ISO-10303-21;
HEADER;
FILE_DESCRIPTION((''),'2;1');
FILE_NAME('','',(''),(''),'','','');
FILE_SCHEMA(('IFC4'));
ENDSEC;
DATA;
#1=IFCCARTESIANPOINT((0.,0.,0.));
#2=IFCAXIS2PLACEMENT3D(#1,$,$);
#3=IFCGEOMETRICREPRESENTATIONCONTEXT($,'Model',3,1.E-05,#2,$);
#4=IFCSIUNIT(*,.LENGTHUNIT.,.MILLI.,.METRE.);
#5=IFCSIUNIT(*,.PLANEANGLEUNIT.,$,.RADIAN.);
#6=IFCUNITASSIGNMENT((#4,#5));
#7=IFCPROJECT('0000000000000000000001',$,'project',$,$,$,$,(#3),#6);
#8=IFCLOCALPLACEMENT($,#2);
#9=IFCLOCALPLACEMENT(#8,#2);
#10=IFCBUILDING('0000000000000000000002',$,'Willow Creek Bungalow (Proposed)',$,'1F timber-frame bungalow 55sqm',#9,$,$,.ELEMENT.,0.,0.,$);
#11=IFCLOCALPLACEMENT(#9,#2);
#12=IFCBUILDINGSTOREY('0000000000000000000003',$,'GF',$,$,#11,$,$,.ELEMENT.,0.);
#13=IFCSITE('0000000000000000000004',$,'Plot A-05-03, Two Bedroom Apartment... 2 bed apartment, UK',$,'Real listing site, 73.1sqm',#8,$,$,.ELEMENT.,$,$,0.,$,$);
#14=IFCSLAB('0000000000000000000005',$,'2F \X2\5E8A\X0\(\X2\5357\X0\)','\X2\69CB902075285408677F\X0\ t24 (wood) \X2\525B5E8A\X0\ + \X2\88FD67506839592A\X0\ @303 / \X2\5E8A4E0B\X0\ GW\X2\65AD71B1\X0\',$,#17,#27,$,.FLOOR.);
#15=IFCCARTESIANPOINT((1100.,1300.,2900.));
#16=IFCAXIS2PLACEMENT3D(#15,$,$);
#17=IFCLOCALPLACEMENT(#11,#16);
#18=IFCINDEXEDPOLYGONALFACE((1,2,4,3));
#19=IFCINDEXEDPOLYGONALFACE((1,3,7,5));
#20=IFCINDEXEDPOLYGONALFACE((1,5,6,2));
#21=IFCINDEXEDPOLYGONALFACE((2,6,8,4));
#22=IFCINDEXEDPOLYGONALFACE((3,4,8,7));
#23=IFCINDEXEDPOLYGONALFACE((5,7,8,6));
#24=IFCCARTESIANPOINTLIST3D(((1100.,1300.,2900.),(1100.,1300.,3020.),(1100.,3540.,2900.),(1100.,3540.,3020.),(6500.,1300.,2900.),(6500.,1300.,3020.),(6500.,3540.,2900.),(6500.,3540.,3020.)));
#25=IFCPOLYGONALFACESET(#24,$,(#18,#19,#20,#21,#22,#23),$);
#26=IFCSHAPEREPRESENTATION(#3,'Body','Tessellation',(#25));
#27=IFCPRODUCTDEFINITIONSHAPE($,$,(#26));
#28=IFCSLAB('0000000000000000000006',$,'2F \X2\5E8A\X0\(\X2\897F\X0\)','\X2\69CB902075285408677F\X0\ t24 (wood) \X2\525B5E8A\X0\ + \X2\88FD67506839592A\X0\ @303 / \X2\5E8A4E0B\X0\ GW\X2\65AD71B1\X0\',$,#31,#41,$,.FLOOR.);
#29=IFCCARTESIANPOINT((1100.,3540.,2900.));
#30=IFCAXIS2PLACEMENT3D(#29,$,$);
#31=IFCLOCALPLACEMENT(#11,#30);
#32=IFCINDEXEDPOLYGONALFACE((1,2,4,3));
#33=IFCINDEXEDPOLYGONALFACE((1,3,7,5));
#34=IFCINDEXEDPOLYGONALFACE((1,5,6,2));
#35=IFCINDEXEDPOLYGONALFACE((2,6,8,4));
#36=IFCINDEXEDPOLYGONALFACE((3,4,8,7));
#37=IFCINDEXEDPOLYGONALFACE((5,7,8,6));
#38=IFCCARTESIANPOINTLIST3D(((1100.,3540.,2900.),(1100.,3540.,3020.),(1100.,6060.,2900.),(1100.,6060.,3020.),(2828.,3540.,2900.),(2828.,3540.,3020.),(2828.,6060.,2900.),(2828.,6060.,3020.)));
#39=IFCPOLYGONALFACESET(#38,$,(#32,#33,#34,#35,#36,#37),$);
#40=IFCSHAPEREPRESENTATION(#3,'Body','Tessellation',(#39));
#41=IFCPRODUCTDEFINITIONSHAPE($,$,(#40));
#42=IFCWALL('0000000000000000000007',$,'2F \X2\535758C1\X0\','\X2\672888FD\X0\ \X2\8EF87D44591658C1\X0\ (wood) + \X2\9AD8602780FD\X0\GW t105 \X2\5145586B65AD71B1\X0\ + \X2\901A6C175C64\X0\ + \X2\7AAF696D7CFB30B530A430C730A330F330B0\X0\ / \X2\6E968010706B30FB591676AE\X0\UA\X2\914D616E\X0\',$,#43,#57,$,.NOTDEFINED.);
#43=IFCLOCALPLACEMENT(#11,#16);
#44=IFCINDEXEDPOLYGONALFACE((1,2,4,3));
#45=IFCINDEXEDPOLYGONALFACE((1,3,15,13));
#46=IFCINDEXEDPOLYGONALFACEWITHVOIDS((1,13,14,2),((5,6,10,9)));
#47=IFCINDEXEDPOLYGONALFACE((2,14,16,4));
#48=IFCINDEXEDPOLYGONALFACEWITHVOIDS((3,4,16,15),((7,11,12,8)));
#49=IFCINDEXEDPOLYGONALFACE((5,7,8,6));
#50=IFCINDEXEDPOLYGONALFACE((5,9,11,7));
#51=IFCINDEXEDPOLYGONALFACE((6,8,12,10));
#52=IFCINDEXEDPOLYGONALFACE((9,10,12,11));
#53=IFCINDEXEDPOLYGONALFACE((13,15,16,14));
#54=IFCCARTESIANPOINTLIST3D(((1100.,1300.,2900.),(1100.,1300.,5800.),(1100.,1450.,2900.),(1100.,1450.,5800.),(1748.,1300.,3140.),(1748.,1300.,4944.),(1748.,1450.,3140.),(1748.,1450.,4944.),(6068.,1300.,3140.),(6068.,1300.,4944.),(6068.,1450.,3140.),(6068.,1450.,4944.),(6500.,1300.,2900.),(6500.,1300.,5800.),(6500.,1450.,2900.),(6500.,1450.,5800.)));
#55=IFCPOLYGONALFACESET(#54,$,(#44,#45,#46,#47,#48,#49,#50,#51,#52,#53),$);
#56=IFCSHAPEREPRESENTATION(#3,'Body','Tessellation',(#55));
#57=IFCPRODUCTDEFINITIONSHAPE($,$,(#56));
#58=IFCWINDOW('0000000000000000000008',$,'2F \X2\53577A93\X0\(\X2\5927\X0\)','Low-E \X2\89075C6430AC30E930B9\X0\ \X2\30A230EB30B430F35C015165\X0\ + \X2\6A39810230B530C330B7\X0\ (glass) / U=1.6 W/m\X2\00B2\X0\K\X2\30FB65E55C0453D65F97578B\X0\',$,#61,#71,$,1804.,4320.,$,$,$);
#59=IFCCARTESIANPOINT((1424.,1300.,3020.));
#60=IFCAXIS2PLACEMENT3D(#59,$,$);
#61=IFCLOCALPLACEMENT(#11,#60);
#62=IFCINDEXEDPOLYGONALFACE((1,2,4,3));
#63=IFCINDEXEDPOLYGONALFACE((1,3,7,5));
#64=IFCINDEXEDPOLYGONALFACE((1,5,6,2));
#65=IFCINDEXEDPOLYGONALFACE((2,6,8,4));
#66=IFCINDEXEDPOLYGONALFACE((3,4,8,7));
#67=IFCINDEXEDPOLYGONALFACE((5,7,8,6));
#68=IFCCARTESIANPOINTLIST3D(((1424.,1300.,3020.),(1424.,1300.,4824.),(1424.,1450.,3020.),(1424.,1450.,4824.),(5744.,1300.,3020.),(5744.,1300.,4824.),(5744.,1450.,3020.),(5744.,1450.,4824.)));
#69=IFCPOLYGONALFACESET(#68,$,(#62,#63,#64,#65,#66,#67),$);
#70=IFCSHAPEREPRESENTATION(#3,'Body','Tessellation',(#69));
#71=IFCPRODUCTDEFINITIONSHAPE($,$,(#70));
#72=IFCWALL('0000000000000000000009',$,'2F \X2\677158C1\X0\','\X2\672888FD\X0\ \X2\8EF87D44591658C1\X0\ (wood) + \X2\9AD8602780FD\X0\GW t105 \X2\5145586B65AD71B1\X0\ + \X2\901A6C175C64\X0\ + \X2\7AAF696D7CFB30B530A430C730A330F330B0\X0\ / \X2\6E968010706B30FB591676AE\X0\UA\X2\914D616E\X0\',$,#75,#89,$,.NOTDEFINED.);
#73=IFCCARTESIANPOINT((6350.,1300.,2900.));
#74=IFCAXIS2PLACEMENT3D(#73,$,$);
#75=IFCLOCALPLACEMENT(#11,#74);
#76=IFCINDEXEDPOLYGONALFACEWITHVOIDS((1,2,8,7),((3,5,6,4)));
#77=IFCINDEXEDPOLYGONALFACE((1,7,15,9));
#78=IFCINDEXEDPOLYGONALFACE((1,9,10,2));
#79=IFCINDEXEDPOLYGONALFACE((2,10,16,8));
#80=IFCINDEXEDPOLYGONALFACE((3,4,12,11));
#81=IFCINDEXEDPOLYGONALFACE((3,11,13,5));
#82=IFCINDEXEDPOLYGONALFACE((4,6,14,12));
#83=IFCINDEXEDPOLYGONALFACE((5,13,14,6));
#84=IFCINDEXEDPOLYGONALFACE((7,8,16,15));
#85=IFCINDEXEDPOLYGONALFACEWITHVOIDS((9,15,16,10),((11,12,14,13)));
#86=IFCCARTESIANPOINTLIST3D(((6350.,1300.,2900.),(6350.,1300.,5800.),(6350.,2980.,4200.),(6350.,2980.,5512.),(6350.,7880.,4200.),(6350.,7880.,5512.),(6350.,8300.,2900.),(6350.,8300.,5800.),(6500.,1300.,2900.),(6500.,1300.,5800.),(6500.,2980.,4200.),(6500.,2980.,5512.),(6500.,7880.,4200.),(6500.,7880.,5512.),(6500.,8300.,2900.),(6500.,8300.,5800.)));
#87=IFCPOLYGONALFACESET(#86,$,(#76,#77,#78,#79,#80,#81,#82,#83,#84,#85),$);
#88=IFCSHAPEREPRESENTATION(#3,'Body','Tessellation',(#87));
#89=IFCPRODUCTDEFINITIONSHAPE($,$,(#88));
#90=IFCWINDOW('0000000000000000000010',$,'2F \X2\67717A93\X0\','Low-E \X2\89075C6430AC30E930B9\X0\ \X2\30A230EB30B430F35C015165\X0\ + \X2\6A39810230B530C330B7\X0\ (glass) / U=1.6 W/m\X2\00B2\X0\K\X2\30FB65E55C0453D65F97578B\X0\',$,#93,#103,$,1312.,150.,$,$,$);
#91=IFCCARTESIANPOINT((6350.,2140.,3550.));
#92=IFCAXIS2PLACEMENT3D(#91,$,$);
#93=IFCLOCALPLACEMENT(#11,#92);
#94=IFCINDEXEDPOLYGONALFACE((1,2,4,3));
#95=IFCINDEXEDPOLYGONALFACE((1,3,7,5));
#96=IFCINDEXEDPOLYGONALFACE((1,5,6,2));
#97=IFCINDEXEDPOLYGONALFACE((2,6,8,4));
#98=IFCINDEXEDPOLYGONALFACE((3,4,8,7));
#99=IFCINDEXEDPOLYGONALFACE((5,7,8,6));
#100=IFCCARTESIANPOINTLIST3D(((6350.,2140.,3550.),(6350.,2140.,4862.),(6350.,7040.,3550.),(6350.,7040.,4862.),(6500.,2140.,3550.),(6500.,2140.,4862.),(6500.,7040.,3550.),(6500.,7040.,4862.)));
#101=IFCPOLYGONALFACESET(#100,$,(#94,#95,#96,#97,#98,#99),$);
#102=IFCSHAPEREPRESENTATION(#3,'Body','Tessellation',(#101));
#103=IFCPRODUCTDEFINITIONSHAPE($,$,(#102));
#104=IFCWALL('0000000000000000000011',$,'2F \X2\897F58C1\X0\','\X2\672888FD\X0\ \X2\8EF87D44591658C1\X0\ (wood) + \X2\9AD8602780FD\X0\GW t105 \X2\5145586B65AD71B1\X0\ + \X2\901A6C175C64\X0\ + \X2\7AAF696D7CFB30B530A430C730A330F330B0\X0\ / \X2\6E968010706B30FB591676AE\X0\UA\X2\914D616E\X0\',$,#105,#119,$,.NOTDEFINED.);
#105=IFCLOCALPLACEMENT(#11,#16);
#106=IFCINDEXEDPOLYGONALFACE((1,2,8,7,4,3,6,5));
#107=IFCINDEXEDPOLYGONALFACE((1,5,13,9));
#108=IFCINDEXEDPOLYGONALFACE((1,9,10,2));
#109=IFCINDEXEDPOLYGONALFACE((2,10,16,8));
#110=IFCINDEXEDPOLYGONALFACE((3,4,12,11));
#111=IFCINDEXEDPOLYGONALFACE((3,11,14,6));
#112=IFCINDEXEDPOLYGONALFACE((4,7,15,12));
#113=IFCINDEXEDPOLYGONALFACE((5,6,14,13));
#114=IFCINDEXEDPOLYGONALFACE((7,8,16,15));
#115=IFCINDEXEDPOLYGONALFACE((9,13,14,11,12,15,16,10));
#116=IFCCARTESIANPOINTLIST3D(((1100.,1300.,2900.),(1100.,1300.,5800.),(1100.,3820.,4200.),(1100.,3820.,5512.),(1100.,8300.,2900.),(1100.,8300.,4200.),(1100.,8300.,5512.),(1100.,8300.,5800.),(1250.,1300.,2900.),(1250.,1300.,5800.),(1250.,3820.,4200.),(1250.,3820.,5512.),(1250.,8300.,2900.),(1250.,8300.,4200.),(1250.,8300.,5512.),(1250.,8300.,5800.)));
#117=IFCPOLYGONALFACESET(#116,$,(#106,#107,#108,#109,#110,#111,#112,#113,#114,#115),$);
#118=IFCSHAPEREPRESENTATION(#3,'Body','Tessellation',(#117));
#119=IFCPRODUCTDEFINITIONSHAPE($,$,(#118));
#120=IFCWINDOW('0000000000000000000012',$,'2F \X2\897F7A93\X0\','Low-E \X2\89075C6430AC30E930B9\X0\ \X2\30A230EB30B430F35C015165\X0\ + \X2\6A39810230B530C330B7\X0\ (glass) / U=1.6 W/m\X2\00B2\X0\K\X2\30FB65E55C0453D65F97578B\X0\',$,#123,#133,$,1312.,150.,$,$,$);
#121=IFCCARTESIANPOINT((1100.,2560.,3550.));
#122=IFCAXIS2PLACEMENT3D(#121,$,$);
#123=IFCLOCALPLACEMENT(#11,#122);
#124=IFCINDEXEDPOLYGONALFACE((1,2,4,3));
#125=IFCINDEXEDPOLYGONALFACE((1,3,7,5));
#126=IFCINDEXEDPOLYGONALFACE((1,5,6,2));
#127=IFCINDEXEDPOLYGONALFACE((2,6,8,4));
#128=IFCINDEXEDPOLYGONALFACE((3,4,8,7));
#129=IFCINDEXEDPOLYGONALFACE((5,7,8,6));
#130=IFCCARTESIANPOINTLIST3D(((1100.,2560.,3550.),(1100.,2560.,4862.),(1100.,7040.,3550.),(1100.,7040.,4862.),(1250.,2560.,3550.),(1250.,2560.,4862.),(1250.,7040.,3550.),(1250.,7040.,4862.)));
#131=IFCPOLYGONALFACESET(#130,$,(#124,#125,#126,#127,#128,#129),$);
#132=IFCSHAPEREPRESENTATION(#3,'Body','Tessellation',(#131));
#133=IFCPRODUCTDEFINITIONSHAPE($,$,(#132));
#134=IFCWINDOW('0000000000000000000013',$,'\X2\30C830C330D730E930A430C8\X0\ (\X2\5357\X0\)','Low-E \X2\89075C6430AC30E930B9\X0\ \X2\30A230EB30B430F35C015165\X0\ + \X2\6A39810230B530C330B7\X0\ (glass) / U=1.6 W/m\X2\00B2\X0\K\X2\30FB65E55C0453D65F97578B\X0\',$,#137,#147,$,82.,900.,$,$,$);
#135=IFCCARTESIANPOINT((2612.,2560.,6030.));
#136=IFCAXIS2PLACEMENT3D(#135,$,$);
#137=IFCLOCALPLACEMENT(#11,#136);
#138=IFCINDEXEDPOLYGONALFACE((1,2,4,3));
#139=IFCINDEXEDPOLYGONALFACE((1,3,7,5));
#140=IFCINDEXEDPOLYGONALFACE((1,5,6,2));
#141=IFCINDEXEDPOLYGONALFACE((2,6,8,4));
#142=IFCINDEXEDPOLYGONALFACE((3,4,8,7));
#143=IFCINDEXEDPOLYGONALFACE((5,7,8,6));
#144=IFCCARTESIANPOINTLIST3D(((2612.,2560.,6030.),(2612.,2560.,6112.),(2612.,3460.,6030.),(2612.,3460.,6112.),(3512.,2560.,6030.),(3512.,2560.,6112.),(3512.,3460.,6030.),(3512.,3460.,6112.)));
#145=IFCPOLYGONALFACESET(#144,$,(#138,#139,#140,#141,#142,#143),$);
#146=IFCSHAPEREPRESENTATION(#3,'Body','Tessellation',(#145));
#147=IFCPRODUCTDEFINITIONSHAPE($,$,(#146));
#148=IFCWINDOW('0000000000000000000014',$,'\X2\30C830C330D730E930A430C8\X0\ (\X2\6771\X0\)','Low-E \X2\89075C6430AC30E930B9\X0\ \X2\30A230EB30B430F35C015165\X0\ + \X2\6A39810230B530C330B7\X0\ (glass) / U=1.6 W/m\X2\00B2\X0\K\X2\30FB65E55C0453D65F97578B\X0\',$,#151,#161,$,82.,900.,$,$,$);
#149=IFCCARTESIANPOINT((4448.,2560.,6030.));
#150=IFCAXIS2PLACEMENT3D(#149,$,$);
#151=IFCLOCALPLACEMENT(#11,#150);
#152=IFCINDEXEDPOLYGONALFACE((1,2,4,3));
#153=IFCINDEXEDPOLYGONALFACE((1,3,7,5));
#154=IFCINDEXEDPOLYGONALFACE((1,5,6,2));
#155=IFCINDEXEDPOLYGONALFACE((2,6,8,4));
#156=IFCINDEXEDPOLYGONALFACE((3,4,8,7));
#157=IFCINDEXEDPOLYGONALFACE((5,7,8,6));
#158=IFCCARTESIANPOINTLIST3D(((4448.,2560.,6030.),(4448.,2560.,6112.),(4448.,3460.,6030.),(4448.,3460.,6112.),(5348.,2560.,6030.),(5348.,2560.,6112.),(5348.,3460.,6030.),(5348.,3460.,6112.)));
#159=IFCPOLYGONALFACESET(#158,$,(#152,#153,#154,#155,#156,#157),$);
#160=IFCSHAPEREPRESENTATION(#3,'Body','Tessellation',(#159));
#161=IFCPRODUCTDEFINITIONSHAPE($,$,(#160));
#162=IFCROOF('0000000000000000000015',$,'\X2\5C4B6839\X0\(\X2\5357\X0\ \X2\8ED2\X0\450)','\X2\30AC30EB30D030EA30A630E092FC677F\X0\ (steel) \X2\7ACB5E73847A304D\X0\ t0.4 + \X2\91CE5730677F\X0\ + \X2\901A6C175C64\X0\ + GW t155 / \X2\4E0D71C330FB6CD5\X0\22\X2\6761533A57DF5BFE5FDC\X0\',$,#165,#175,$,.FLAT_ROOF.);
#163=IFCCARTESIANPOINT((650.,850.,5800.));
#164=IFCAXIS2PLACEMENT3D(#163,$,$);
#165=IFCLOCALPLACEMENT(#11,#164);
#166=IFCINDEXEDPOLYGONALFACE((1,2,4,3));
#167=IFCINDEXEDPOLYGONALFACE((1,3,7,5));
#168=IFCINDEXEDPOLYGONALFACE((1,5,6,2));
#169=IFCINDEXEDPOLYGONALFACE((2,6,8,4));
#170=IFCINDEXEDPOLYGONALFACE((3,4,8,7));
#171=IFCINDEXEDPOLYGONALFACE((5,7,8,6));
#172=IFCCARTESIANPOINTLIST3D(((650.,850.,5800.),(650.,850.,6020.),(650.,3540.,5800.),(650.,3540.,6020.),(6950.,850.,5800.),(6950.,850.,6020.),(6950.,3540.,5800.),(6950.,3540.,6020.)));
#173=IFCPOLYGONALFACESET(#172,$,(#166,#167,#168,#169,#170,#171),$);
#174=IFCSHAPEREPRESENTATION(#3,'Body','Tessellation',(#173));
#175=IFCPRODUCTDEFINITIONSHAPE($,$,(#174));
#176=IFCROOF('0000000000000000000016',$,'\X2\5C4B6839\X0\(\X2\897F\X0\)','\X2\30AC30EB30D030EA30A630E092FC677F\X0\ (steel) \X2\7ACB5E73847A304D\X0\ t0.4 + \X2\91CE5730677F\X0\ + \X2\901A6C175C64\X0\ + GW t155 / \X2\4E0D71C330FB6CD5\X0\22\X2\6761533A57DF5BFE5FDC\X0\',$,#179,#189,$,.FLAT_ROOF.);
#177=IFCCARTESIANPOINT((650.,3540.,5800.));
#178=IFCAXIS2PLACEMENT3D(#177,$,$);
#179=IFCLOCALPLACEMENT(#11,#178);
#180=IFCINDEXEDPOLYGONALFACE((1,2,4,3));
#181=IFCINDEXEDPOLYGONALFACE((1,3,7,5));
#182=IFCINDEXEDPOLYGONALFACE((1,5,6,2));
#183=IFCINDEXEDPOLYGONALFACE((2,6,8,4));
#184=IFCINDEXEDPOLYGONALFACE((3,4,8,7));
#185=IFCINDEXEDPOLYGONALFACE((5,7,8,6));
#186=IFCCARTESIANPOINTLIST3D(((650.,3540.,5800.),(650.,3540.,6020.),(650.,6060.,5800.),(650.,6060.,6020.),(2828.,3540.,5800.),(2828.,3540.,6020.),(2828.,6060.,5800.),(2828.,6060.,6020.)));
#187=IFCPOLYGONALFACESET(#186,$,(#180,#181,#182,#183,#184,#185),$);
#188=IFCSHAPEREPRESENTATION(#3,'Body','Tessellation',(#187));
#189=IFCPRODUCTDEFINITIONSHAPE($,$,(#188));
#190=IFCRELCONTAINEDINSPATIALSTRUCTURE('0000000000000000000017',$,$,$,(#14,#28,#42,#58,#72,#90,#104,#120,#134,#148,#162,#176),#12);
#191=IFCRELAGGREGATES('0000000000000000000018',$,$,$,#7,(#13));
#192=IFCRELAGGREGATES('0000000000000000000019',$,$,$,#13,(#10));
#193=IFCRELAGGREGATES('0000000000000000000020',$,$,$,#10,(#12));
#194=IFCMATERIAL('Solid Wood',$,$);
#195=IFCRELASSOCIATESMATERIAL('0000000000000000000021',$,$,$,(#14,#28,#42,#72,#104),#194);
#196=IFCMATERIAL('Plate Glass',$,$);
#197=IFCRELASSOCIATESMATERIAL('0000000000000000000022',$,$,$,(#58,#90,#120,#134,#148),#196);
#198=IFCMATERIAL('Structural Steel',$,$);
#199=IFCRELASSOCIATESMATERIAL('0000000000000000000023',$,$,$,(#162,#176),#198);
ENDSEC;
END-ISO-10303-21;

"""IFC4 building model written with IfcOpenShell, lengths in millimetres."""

from ifc_helpers import new_model, si_unit, frame, frame_2d, origin, place, context, project, spatial, rectangle, extrude, material, element, fill, save


model = new_model("IFC4")

# Units and contexts
model_context = context("Model", 3, precision=1e-05, world=origin())
ifc_project = project(units=[si_unit("LENGTHUNIT", "METRE", prefix="MILLI"), si_unit("PLANEANGLEUNIT", "RADIAN")], contexts=[model_context])

# Site, building, storey
site_placement = place(None, origin())
site = spatial("IfcSite", under=ifc_project, at=site_placement, Name="Plot A-05-03, Two Bedroom Apartment... 2 bed apartment, UK", ObjectType="Real listing site, 73.1sqm", CompositionType="ELEMENT", RefElevation=0.0)
building_placement = place(site_placement, origin())
building = spatial("IfcBuilding", under=site, at=building_placement, Name="Willow Creek Bungalow (Proposed)", ObjectType="1F timber-frame bungalow 55sqm", CompositionType="ELEMENT", ElevationOfRefHeight=0.0, ElevationOfTerrain=0.0)
storey_placement = place(building_placement, origin())
storey = spatial("IfcBuildingStorey", under=building, at=storey_placement, Name="GF", CompositionType="ELEMENT", Elevation=0.0)

# Slabs
ifc_material_1 = material(Name="Solid Wood")
slab_1_placement = place(storey_placement, frame((1100.0, 1300.0, 2900.0)))
element("IfcSlab", 1, at=slab_1_placement, inside=storey, material=ifc_material_1, Name="2F 床(南)", Description="構造用合板 t24 (wood) 剛床 + 製材根太 @303 / 床下 GW断熱", PredefinedType="FLOOR", context=model_context, shape_type="SweptSolid", body=[
    extrude(rectangle(XDim=5400.0, YDim=2240.0, at=frame_2d((2700.0, 1120.0))), frame((1100.0, 1300.0, 2900.0)), (0.0, 0.0, 1.0), 120.0),
])
slab_2_placement = place(storey_placement, frame((1100.0, 3540.0, 2900.0)))
element("IfcSlab", 2, at=slab_2_placement, inside=storey, material=ifc_material_1, Name="2F 床(西)", Description="構造用合板 t24 (wood) 剛床 + 製材根太 @303 / 床下 GW断熱", PredefinedType="FLOOR", context=model_context, shape_type="SweptSolid", body=[
    extrude(rectangle(XDim=1728.0, YDim=2520.0, at=frame_2d((864.0, 1260.0))), frame((1100.0, 3540.0, 2900.0)), (0.0, 0.0, 1.0), 120.0),
])

# Walls, openings, windows
wall_1_placement = place(storey_placement, frame((1100.0, 1300.0, 2900.0)))
wall_1 = element("IfcWall", 3, at=wall_1_placement, inside=storey, material=ifc_material_1, Name="2F 南壁", Description="木製 軸組外壁 (wood) + 高性能GW t105 充填断熱 + 通気層 + 窯業系サイディング / 準耐火・外皮UA配慮", PredefinedType="NOTDEFINED", context=model_context, shape_type="SweptSolid", body=[
    extrude(rectangle(XDim=5400.0, YDim=150.0, at=frame_2d((2700.0, 75.0))), frame((1100.0, 1300.0, 2900.0)), (0.0, 0.0, 1.0), 2900.0),
])
opening_1_placement = place(storey_placement, frame((1424.0, 1300.0, 3020.0)))
opening_1 = element("IfcOpeningElement", 4, at=opening_1_placement, cuts=wall_1, PredefinedType="NOTDEFINED", context=model_context, shape_type="SweptSolid", body=[
    extrude(rectangle(XDim=4320.0, YDim=150.0, at=frame_2d((2160.0, 75.0))), frame((1424.0, 1300.0, 3020.0)), (0.0, 0.0, 1.0), 1804.0),
])
ifc_material_2 = material(Name="Plate Glass")
window_1_placement = place(storey_placement, frame((1424.0, 1300.0, 3020.0)))
window_1 = element("IfcWindow", 5, at=window_1_placement, inside=storey, material=ifc_material_2, Name="2F 南窓(大)", Description="Low-E 複層ガラス アルゴン封入 + 樹脂サッシ (glass) / U=1.6 W/m²K・日射取得型", OverallHeight=1804.0, OverallWidth=4320.0, context=model_context, shape_type="SweptSolid", body=[
    extrude(rectangle(XDim=4320.0, YDim=150.0, at=frame_2d((2160.0, 75.0))), frame((1424.0, 1300.0, 3020.0)), (0.0, 0.0, 1.0), 1804.0),
])
fill(opening_1, window_1)
wall_2_placement = place(storey_placement, frame((6350.0, 1300.0, 2900.0)))
wall_2 = element("IfcWall", 6, at=wall_2_placement, inside=storey, material=ifc_material_1, Name="2F 東壁", Description="木製 軸組外壁 (wood) + 高性能GW t105 充填断熱 + 通気層 + 窯業系サイディング / 準耐火・外皮UA配慮", PredefinedType="NOTDEFINED", context=model_context, shape_type="SweptSolid", body=[
    extrude(rectangle(XDim=150.0, YDim=7000.0, at=frame_2d((75.0, 3500.0))), frame((6350.0, 1300.0, 2900.0)), (0.0, 0.0, 1.0), 2900.0),
])
opening_2_placement = place(storey_placement, frame((6350.0, 2140.0, 3550.0)))
opening_2 = element("IfcOpeningElement", 7, at=opening_2_placement, cuts=wall_2, PredefinedType="NOTDEFINED", context=model_context, shape_type="SweptSolid", body=[
    extrude(rectangle(XDim=150.0, YDim=4900.0, at=frame_2d((75.0, 2450.0))), frame((6350.0, 2140.0, 3550.0)), (0.0, 0.0, 1.0), 1312.0),
])
window_2_placement = place(storey_placement, frame((6350.0, 2140.0, 3550.0)))
window_2 = element("IfcWindow", 8, at=window_2_placement, inside=storey, material=ifc_material_2, Name="2F 東窓", Description="Low-E 複層ガラス アルゴン封入 + 樹脂サッシ (glass) / U=1.6 W/m²K・日射取得型", OverallHeight=1312.0, OverallWidth=150.0, context=model_context, shape_type="SweptSolid", body=[
    extrude(rectangle(XDim=150.0, YDim=4900.0, at=frame_2d((75.0, 2450.0))), frame((6350.0, 2140.0, 3550.0)), (0.0, 0.0, 1.0), 1312.0),
])
fill(opening_2, window_2)
wall_3_placement = place(storey_placement, frame((1100.0, 1300.0, 2900.0)))
wall_3 = element("IfcWall", 9, at=wall_3_placement, inside=storey, material=ifc_material_1, Name="2F 西壁", Description="木製 軸組外壁 (wood) + 高性能GW t105 充填断熱 + 通気層 + 窯業系サイディング / 準耐火・外皮UA配慮", PredefinedType="NOTDEFINED", context=model_context, shape_type="SweptSolid", body=[
    extrude(rectangle(XDim=150.0, YDim=7000.0, at=frame_2d((75.0, 3500.0))), frame((1100.0, 1300.0, 2900.0)), (0.0, 0.0, 1.0), 2900.0),
])
opening_3_placement = place(storey_placement, frame((1100.0, 2560.0, 3550.0)))
opening_3 = element("IfcOpeningElement", 10, at=opening_3_placement, cuts=wall_3, PredefinedType="NOTDEFINED", context=model_context, shape_type="SweptSolid", body=[
    extrude(rectangle(XDim=150.0, YDim=4480.0, at=frame_2d((75.0, 2240.0))), frame((1100.0, 2560.0, 3550.0)), (0.0, 0.0, 1.0), 1312.0),
])
window_3_placement = place(storey_placement, frame((1100.0, 2560.0, 3550.0)))
window_3 = element("IfcWindow", 11, at=window_3_placement, inside=storey, material=ifc_material_2, Name="2F 西窓", Description="Low-E 複層ガラス アルゴン封入 + 樹脂サッシ (glass) / U=1.6 W/m²K・日射取得型", OverallHeight=1312.0, OverallWidth=150.0, context=model_context, shape_type="SweptSolid", body=[
    extrude(rectangle(XDim=150.0, YDim=4480.0, at=frame_2d((75.0, 2240.0))), frame((1100.0, 2560.0, 3550.0)), (0.0, 0.0, 1.0), 1312.0),
])
fill(opening_3, window_3)

# Windows
window_4_placement = place(storey_placement, frame((2612.0, 2560.0, 6030.0)))
element("IfcWindow", 12, at=window_4_placement, inside=storey, material=ifc_material_2, Name="トップライト (南)", Description="Low-E 複層ガラス アルゴン封入 + 樹脂サッシ (glass) / U=1.6 W/m²K・日射取得型", OverallHeight=82.0, OverallWidth=900.0, context=model_context, shape_type="SweptSolid", body=[
    extrude(rectangle(XDim=900.0, YDim=900.0, at=frame_2d((450.0, 450.0))), frame((2612.0, 2560.0, 6030.0)), (0.0, 0.0, 1.0), 82.0),
])
window_5_placement = place(storey_placement, frame((4448.0, 2560.0, 6030.0)))
element("IfcWindow", 13, at=window_5_placement, inside=storey, material=ifc_material_2, Name="トップライト (東)", Description="Low-E 複層ガラス アルゴン封入 + 樹脂サッシ (glass) / U=1.6 W/m²K・日射取得型", OverallHeight=82.0, OverallWidth=900.0, context=model_context, shape_type="SweptSolid", body=[
    extrude(rectangle(XDim=900.0, YDim=900.0, at=frame_2d((450.0, 450.0))), frame((4448.0, 2560.0, 6030.0)), (0.0, 0.0, 1.0), 82.0),
])

# Roofs
ifc_material_3 = material(Name="Structural Steel")
roof_1_placement = place(storey_placement, frame((650.0, 850.0, 5800.0)))
element("IfcRoof", 14, at=roof_1_placement, inside=storey, material=ifc_material_3, Name="屋根(南 軒450)", Description="ガルバリウム鋼板 (steel) 立平葺き t0.4 + 野地板 + 通気層 + GW t155 / 不燃・法22条区域対応", PredefinedType="FLAT_ROOF", context=model_context, shape_type="SweptSolid", body=[
    extrude(rectangle(XDim=6300.0, YDim=2690.0, at=frame_2d((3150.0, 1345.0))), frame((650.0, 850.0, 5800.0)), (0.0, 0.0, 1.0), 220.0),
])
roof_2_placement = place(storey_placement, frame((650.0, 3540.0, 5800.0)))
element("IfcRoof", 15, at=roof_2_placement, inside=storey, material=ifc_material_3, Name="屋根(西)", Description="ガルバリウム鋼板 (steel) 立平葺き t0.4 + 野地板 + 通気層 + GW t155 / 不燃・法22条区域対応", PredefinedType="FLAT_ROOF", context=model_context, shape_type="SweptSolid", body=[
    extrude(rectangle(XDim=2178.0, YDim=2520.0, at=frame_2d((1089.0, 1260.0))), frame((650.0, 3540.0, 5800.0)), (0.0, 0.0, 1.0), 220.0),
])

save(model, "model.ifc")
